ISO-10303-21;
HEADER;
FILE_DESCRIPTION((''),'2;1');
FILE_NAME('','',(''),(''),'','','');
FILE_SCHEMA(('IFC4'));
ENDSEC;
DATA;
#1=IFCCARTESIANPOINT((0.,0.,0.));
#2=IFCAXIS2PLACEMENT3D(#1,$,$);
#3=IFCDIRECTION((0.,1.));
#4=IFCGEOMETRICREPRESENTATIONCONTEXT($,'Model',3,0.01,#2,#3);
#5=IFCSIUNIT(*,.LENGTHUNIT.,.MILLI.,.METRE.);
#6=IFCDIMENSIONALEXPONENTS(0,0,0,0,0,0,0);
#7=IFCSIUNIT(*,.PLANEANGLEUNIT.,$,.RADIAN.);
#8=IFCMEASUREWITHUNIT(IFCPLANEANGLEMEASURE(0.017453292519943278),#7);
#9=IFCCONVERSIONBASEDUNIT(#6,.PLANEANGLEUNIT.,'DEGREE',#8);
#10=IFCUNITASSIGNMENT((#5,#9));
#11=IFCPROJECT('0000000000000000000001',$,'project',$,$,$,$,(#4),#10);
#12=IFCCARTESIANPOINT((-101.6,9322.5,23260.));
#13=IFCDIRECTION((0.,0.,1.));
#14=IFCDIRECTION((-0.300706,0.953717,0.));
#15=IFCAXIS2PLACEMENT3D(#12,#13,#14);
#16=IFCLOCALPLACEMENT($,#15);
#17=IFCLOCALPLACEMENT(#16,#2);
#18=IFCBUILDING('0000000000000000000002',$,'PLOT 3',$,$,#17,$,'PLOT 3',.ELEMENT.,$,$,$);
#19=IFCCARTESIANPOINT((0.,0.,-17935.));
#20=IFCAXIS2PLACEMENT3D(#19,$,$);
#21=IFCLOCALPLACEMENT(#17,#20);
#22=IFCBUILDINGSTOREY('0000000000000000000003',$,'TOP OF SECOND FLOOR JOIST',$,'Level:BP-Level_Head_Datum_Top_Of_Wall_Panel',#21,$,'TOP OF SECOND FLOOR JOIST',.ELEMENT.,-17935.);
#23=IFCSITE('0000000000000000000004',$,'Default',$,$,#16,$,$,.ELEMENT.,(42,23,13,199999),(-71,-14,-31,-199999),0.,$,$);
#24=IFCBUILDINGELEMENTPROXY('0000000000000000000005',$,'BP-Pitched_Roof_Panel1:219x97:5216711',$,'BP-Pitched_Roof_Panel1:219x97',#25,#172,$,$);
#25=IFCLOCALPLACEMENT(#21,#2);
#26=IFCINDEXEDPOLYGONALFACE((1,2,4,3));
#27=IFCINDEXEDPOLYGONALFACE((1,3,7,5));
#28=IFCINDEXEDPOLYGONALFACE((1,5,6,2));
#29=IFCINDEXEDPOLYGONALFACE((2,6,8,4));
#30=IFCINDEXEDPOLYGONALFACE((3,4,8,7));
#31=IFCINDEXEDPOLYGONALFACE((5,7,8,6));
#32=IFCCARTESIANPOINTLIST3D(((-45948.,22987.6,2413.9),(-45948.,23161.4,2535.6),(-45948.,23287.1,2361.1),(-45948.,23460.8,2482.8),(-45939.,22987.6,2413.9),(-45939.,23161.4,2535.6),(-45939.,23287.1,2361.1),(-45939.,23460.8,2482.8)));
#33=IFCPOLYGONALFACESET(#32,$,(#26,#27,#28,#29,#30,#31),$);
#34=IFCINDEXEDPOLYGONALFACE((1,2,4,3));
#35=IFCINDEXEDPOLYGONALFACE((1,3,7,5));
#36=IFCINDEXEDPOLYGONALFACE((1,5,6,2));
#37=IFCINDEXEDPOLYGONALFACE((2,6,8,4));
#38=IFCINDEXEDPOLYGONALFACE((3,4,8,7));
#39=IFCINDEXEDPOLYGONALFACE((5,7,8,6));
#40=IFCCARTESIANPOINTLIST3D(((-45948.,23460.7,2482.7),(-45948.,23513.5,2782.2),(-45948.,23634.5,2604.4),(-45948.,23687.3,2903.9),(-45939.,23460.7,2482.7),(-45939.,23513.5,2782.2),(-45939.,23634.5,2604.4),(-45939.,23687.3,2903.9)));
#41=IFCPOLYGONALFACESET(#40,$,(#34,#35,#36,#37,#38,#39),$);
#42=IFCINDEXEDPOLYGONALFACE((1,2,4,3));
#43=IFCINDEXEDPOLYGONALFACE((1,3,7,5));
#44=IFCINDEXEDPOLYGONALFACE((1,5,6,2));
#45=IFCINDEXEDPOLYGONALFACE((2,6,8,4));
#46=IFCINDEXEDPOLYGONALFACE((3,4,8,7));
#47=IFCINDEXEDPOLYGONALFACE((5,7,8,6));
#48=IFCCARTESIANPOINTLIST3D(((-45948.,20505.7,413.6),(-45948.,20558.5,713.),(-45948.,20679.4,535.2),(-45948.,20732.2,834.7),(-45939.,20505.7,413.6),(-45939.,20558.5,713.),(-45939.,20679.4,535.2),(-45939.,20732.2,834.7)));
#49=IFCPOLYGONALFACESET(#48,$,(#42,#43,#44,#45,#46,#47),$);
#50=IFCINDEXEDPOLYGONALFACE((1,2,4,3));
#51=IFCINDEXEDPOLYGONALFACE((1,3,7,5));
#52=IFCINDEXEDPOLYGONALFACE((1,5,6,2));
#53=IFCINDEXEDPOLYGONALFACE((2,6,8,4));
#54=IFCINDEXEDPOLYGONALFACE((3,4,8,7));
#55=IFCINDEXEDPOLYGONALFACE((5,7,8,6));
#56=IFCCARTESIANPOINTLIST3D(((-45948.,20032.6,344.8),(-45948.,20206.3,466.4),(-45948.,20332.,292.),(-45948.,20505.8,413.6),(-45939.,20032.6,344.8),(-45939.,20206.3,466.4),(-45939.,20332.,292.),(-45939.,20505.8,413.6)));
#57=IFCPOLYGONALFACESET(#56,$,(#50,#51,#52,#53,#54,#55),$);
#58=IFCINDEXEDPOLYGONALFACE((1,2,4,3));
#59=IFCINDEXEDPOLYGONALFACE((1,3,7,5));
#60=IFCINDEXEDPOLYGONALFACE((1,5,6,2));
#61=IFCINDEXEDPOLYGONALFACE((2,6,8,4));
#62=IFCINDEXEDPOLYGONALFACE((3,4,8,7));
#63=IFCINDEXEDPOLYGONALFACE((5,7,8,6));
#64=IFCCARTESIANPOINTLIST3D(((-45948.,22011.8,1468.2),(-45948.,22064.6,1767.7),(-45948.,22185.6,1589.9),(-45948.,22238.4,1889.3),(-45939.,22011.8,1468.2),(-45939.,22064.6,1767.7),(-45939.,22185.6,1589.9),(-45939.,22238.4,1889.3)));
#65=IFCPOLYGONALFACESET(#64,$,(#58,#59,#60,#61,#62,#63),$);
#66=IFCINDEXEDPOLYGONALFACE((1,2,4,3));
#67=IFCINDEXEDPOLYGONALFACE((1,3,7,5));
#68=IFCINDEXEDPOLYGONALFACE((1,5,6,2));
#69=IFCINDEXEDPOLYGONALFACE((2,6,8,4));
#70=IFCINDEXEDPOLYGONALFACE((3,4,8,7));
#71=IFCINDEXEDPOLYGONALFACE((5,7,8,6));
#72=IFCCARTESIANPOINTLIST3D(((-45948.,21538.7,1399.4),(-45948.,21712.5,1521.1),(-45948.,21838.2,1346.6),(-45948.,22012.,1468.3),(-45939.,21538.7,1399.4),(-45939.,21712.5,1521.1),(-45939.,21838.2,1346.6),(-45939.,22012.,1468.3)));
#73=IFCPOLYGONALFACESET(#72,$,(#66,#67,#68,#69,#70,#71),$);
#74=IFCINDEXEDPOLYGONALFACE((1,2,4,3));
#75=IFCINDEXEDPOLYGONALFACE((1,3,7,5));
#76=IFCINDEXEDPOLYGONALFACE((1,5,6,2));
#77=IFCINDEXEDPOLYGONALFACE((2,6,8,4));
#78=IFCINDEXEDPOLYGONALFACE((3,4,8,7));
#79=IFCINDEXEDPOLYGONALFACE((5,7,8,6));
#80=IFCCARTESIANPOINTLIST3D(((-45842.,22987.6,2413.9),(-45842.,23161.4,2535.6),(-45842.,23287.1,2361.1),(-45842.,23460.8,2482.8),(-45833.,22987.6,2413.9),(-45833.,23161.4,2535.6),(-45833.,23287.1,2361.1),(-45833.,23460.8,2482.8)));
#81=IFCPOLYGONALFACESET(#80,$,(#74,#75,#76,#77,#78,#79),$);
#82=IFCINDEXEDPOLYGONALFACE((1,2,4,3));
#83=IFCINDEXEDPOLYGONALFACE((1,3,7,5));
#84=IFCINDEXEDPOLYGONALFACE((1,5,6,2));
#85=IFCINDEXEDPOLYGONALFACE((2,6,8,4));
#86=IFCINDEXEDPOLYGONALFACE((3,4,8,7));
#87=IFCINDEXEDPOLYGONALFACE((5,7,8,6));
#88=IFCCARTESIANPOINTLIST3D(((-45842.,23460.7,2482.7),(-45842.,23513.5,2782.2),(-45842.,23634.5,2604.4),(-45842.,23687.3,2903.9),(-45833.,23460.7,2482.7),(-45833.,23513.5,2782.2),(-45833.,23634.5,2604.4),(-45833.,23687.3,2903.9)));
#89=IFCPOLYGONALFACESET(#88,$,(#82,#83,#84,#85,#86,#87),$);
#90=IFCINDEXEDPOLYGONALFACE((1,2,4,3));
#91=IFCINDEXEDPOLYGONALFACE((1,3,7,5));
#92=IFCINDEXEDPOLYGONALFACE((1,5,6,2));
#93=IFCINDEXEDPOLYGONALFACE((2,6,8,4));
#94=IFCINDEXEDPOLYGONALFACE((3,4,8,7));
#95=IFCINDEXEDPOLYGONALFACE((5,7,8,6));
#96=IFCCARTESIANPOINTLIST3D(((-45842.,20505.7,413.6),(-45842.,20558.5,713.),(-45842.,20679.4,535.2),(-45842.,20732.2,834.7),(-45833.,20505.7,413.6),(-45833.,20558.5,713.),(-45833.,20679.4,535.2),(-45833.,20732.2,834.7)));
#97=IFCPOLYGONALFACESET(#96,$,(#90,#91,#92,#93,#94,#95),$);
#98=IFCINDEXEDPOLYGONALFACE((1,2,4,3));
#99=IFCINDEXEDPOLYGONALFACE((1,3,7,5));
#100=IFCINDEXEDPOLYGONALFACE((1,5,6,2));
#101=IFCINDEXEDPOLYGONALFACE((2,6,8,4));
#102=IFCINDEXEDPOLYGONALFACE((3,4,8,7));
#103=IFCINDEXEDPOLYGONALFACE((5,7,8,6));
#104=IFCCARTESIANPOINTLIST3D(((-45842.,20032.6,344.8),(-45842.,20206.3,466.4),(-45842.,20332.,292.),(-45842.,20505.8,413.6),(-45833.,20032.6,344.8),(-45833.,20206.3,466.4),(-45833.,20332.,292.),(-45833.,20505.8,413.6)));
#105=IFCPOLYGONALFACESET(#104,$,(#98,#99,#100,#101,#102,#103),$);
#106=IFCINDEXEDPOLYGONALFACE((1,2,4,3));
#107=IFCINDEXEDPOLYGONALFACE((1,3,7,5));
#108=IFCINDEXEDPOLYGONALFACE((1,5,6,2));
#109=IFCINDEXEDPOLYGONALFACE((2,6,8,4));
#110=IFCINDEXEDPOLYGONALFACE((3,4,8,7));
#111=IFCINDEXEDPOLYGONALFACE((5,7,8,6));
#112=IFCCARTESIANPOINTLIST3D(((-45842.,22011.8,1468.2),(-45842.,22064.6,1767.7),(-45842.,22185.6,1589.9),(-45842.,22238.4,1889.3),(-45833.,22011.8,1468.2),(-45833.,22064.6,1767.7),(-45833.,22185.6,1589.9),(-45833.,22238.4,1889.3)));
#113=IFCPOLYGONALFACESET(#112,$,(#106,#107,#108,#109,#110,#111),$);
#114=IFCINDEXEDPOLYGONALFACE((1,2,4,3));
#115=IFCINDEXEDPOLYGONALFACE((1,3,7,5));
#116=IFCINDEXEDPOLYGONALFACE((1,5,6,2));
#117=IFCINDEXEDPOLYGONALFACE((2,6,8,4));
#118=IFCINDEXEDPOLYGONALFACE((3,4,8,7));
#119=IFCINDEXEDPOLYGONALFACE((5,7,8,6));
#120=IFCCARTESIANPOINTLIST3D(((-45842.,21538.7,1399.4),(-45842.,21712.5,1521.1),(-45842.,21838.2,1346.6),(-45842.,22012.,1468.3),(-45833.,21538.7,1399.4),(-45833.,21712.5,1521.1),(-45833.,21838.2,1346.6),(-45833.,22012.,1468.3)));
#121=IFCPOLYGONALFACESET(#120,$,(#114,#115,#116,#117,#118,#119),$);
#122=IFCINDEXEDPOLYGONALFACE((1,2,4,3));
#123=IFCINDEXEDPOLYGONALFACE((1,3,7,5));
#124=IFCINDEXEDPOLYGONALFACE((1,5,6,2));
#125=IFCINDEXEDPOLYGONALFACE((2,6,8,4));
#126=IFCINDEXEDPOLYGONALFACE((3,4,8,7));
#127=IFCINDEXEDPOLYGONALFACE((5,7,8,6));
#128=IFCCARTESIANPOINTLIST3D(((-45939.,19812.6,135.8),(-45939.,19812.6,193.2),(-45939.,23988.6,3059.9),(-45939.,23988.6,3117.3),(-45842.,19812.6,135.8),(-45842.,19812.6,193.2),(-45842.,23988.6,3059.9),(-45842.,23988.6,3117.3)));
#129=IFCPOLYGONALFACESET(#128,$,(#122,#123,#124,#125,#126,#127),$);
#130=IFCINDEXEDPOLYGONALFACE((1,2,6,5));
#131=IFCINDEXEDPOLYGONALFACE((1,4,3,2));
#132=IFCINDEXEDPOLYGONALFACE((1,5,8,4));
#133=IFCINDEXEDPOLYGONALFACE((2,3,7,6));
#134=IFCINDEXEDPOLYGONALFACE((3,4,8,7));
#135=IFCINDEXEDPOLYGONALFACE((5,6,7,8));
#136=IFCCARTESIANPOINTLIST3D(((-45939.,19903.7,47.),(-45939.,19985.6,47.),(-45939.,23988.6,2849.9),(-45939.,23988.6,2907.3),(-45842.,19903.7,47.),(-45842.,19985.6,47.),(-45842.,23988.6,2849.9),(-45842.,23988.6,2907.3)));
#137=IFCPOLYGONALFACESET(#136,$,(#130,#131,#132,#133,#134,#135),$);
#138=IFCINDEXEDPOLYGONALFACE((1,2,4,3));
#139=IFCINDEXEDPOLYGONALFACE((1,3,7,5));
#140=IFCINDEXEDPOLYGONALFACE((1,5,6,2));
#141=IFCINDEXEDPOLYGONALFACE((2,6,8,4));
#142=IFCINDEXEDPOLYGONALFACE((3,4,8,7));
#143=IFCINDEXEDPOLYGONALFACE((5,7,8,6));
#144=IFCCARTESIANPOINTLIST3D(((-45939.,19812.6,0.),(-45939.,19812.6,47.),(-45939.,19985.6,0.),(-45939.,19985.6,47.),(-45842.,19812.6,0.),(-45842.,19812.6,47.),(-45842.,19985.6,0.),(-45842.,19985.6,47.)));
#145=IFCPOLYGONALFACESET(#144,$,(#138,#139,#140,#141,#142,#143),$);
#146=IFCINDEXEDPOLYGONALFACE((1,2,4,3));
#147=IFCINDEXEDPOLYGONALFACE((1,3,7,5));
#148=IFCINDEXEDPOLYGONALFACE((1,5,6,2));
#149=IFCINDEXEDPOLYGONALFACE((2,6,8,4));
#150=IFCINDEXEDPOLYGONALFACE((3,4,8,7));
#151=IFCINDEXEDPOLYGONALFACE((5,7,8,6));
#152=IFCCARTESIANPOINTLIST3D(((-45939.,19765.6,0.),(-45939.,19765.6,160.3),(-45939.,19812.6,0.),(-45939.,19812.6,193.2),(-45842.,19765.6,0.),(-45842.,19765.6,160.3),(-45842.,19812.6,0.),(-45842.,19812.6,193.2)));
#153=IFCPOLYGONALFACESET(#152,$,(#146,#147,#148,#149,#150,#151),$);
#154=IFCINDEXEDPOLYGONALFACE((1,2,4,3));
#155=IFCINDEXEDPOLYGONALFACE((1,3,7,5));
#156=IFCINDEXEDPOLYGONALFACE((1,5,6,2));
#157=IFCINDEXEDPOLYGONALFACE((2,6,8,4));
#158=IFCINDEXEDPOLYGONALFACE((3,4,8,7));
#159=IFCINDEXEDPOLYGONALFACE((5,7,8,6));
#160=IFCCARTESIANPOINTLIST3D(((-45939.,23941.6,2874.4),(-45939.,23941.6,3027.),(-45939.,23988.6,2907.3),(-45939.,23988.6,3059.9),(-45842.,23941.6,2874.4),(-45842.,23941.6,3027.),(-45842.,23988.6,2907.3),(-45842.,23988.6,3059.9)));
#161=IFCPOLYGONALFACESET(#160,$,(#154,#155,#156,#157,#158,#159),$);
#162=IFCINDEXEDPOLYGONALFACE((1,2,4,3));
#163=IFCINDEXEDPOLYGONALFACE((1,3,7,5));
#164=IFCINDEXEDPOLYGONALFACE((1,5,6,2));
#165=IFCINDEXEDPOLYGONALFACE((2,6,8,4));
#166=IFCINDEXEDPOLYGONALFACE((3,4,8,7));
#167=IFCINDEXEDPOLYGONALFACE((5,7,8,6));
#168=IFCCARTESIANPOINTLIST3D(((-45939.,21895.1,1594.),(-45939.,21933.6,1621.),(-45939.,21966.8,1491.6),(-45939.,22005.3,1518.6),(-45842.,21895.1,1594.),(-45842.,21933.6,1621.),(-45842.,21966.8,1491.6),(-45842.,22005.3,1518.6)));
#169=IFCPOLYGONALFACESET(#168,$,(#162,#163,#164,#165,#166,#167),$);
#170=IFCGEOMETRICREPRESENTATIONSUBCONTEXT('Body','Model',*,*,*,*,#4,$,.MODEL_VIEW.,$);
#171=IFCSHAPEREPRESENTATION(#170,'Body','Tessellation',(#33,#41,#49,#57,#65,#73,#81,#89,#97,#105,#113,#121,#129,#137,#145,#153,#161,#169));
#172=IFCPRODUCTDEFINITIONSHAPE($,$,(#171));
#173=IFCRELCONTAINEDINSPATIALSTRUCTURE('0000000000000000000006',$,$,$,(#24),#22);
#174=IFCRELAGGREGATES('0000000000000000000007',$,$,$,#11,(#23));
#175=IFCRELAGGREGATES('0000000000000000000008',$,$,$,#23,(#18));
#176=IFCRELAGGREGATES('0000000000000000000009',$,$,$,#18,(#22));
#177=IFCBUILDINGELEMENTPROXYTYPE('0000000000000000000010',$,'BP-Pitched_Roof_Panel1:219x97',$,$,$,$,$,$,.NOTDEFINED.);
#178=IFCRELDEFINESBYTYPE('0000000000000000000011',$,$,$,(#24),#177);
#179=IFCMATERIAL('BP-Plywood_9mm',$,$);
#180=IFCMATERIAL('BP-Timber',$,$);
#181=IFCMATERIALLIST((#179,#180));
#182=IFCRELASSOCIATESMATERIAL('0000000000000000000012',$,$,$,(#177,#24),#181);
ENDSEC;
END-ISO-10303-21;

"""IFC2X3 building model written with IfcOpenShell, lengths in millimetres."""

from ifc_helpers import new_model, entity, si_unit, converted_unit, direction, frame, frame_2d, origin, origin_2d_with_axis, place, context, subcontext, project, spatial, polyline, rectangle, outline, extrude, source, transform, mapped, material, material_list, type_object, type_shapes, element, save


model = new_model("IFC2X3")

# Units and contexts
model_context = context("Model", 3, precision=0.01, world=origin(), true_north=direction((0.0, 1.0)))
body_context = subcontext(model_context, "Body", "Model", "MODEL_VIEW")
ifc_project = project(units=[si_unit("LENGTHUNIT", "METRE", prefix="MILLI"), converted_unit("PLANEANGLEUNIT", "DEGREE", entity("IfcPlaneAngleMeasure", 0.017453292519943278), si_unit("PLANEANGLEUNIT", "RADIAN"), dimensions=[0, 0, 0, 0, 0, 0, 0])], contexts=[model_context])

# Site, building, storey
site_placement = place(None, frame((-101.6, 9322.5, 23260.0), z_axis=(0.0, 0.0, 1.0), x_axis=(-0.300706, 0.953717, 0.0)))
site = spatial("IfcSite", under=ifc_project, at=site_placement, Name="Default", CompositionType="ELEMENT", RefLatitude=(42, 23, 13, 199999), RefLongitude=(-71, -14, -31, -199999), RefElevation=0.0)
building_placement = place(site_placement, origin())
building = spatial("IfcBuilding", under=site, at=building_placement, Name="PLOT 3", LongName="PLOT 3", CompositionType="ELEMENT")
storey_placement = place(building_placement, frame((0.0, 0.0, -17935.0)))
storey = spatial("IfcBuildingStorey", under=building, at=storey_placement, Name="TOP OF SECOND FLOOR JOIST", ObjectType="Level:BP-Level_Head_Datum_Top_Of_Wall_Panel", LongName="TOP OF SECOND FLOOR JOIST", CompositionType="ELEMENT", Elevation=-17935.0)

# Building element proxy
ifc_material_1 = material(Name="BP-Timber")
ifc_material_2 = material(Name="BP-Plywood_9mm")
ifc_material_list = material_list([ifc_material_2, ifc_material_1])
building_element_proxy_type_1 = type_object("IfcBuildingElementProxyType", Name="BP-Pitched_Roof_Panel1:219x97", PredefinedType="NOTDEFINED", material=ifc_material_list)
shared_shape_1 = source(origin(), body_context, "Body", "SweptSolid", [
    extrude(outline(polyline([(-77.0, -75.0), (227.0, -75.0), (77.0, 75.0), (-227.0, 75.0), (-77.0, -75.0)])), frame((36.3, 3947.0, 2448.4), z_axis=(0.0, 1.0, 0.0), x_axis=(-0.984808, 0.0, 0.173648)), (0.0, 0.0, 1.0), 9.0),
    extrude(outline(polyline([(1.4, -107.5), (213.6, -107.5), (-1.4, 107.5), (-213.6, 107.5), (1.4, -107.5)])), frame((386.1, 3947.0, 2693.3), z_axis=(0.0, 1.0, 0.0), x_axis=(-0.819152, 0.0, -0.573576)), (0.0, 0.0, 1.0), 9.0),
    extrude(outline(polyline([(1.4, -107.5), (213.6, -107.5), (-1.4, 107.5), (-213.6, 107.5), (1.4, -107.5)])), frame((-2569.0, 3947.0, 624.1), z_axis=(0.0, 1.0, 0.0), x_axis=(-0.819152, 0.0, -0.573576)), (0.0, 0.0, 1.0), 9.0),
    extrude(outline(polyline([(-77.0, -75.0), (227.0, -75.0), (77.0, 75.0), (-227.0, 75.0), (-77.0, -75.0)])), frame((-2918.8, 3947.0, 379.2), z_axis=(0.0, 1.0, 0.0), x_axis=(-0.984808, 0.0, 0.173648)), (0.0, 0.0, 1.0), 9.0),
    extrude(outline(polyline([(1.4, -107.5), (213.6, -107.5), (-1.4, 107.5), (-213.6, 107.5), (1.4, -107.5)])), frame((-1062.8, 3947.0, 1678.8), z_axis=(0.0, 1.0, 0.0), x_axis=(-0.819152, 0.0, -0.573576)), (0.0, 0.0, 1.0), 9.0),
    extrude(outline(polyline([(-77.0, -75.0), (227.0, -75.0), (77.0, 75.0), (-227.0, 75.0), (-77.0, -75.0)])), frame((-1412.6, 3947.0, 1433.9), z_axis=(0.0, 1.0, 0.0), x_axis=(-0.984808, 0.0, 0.173648)), (0.0, 0.0, 1.0), 9.0),
    extrude(outline(polyline([(-77.0, -75.0), (227.0, -75.0), (77.0, 75.0), (-227.0, 75.0), (-77.0, -75.0)])), frame((36.3, 3841.0, 2448.4), z_axis=(0.0, 1.0, 0.0), x_axis=(-0.984808, 0.0, 0.173648)), (0.0, 0.0, 1.0), 9.0),
    extrude(outline(polyline([(1.4, -107.5), (213.6, -107.5), (-1.4, 107.5), (-213.6, 107.5), (1.4, -107.5)])), frame((386.1, 3841.0, 2693.3), z_axis=(0.0, 1.0, 0.0), x_axis=(-0.819152, 0.0, -0.573576)), (0.0, 0.0, 1.0), 9.0),
    extrude(outline(polyline([(1.4, -107.5), (213.6, -107.5), (-1.4, 107.5), (-213.6, 107.5), (1.4, -107.5)])), frame((-2569.0, 3841.0, 624.1), z_axis=(0.0, 1.0, 0.0), x_axis=(-0.819152, 0.0, -0.573576)), (0.0, 0.0, 1.0), 9.0),
    extrude(outline(polyline([(-77.0, -75.0), (227.0, -75.0), (77.0, 75.0), (-227.0, 75.0), (-77.0, -75.0)])), frame((-2918.8, 3841.0, 379.2), z_axis=(0.0, 1.0, 0.0), x_axis=(-0.984808, 0.0, 0.173648)), (0.0, 0.0, 1.0), 9.0),
    extrude(outline(polyline([(1.4, -107.5), (213.6, -107.5), (-1.4, 107.5), (-213.6, 107.5), (1.4, -107.5)])), frame((-1062.8, 3841.0, 1678.8), z_axis=(0.0, 1.0, 0.0), x_axis=(-0.819152, 0.0, -0.573576)), (0.0, 0.0, 1.0), 9.0),
    extrude(outline(polyline([(-77.0, -75.0), (227.0, -75.0), (77.0, 75.0), (-227.0, 75.0), (-77.0, -75.0)])), frame((-1412.6, 3841.0, 1433.9), z_axis=(0.0, 1.0, 0.0), x_axis=(-0.984808, 0.0, 0.173648)), (0.0, 0.0, 1.0), 9.0),
    extrude(outline(polyline([(-1490.7, -2088.0), (-1433.3, -2088.0), (1490.7, 2088.0), (1433.3, 2088.0), (-1490.7, -2088.0)])), frame((-1287.3, 3850.0, 1626.6), z_axis=(0.0, 1.0, 0.0), x_axis=(0.0, 0.0, -1.0)), (0.0, 0.0, 1.0), 97.0),
    extrude(outline(polyline([(-1444.5, -2022.0), (-1387.1, -2022.0), (1415.8, 1981.0), (1415.8, 2063.0), (-1444.5, -2022.0)])), frame((-1221.3, 3850.0, 1462.8), z_axis=(0.0, 1.0, 0.0), x_axis=(0.0, 0.0, -1.0)), (0.0, 0.0, 1.0), 97.0),
    extrude(rectangle(XDim=97.0, YDim=173.0, at=origin_2d_with_axis()), frame((-3288.8, 3898.5, 0.0), z_axis=(0.0, 0.0, 1.0), x_axis=(0.0, 1.0, 0.0)), (0.0, 0.0, 1.0), 47.0),
    extrude(outline(polyline([(22.0, -72.4), (79.4, -72.4), (-31.4, 85.9), (-69.9, 58.9), (22.0, -72.4)])), frame((-3398.8, 3850.0, 88.4), z_axis=(0.0, 1.0, 0.0), x_axis=(0.819152, 0.0, 0.573576)), (0.0, 0.0, 1.0), 97.0),
    extrude(outline(polyline([(15.1, -62.5), (72.5, -62.5), (-15.1, 62.5), (-72.5, 62.5), (15.1, -62.5)])), frame((777.2, 3850.0, 2967.2), z_axis=(0.0, 1.0, 0.0), x_axis=(0.819152, 0.0, 0.573576)), (0.0, 0.0, 1.0), 97.0),
    extrude(rectangle(XDim=47.0, YDim=97.0, at=frame_2d((0.0, 0.0), x_axis=(0.0, 1.0))), frame((-1201.9, 3898.5, 1505.1), z_axis=(-0.573576, 0.0, 0.819152), x_axis=(0.0, 1.0, 0.0)), (0.0, 0.0, 1.0), 125.0),
])
type_shapes(building_element_proxy_type_1, [shared_shape_1])
for number, where, z_axis, x_axis, name in (
    (1, (-41992.0, 23187.9, 0.0), (0.0, 0.0, 1.0), (0.0, 1.0, 0.0), "BP-Pitched_Roof_Panel1:219x97:5216711"),
):
    element("IfcBuildingElementProxy", number, at=place(storey_placement, frame(where, z_axis=z_axis, x_axis=x_axis)), inside=storey, type_object=building_element_proxy_type_1, material=ifc_material_list, Name=name, ObjectType="BP-Pitched_Roof_Panel1:219x97", context=body_context, shape_type="MappedRepresentation", body=[
        mapped(shared_shape_1, transform((0.0, 0.0, 0.0), scale=1.0)),
    ])

save(model, "model.ifc")
